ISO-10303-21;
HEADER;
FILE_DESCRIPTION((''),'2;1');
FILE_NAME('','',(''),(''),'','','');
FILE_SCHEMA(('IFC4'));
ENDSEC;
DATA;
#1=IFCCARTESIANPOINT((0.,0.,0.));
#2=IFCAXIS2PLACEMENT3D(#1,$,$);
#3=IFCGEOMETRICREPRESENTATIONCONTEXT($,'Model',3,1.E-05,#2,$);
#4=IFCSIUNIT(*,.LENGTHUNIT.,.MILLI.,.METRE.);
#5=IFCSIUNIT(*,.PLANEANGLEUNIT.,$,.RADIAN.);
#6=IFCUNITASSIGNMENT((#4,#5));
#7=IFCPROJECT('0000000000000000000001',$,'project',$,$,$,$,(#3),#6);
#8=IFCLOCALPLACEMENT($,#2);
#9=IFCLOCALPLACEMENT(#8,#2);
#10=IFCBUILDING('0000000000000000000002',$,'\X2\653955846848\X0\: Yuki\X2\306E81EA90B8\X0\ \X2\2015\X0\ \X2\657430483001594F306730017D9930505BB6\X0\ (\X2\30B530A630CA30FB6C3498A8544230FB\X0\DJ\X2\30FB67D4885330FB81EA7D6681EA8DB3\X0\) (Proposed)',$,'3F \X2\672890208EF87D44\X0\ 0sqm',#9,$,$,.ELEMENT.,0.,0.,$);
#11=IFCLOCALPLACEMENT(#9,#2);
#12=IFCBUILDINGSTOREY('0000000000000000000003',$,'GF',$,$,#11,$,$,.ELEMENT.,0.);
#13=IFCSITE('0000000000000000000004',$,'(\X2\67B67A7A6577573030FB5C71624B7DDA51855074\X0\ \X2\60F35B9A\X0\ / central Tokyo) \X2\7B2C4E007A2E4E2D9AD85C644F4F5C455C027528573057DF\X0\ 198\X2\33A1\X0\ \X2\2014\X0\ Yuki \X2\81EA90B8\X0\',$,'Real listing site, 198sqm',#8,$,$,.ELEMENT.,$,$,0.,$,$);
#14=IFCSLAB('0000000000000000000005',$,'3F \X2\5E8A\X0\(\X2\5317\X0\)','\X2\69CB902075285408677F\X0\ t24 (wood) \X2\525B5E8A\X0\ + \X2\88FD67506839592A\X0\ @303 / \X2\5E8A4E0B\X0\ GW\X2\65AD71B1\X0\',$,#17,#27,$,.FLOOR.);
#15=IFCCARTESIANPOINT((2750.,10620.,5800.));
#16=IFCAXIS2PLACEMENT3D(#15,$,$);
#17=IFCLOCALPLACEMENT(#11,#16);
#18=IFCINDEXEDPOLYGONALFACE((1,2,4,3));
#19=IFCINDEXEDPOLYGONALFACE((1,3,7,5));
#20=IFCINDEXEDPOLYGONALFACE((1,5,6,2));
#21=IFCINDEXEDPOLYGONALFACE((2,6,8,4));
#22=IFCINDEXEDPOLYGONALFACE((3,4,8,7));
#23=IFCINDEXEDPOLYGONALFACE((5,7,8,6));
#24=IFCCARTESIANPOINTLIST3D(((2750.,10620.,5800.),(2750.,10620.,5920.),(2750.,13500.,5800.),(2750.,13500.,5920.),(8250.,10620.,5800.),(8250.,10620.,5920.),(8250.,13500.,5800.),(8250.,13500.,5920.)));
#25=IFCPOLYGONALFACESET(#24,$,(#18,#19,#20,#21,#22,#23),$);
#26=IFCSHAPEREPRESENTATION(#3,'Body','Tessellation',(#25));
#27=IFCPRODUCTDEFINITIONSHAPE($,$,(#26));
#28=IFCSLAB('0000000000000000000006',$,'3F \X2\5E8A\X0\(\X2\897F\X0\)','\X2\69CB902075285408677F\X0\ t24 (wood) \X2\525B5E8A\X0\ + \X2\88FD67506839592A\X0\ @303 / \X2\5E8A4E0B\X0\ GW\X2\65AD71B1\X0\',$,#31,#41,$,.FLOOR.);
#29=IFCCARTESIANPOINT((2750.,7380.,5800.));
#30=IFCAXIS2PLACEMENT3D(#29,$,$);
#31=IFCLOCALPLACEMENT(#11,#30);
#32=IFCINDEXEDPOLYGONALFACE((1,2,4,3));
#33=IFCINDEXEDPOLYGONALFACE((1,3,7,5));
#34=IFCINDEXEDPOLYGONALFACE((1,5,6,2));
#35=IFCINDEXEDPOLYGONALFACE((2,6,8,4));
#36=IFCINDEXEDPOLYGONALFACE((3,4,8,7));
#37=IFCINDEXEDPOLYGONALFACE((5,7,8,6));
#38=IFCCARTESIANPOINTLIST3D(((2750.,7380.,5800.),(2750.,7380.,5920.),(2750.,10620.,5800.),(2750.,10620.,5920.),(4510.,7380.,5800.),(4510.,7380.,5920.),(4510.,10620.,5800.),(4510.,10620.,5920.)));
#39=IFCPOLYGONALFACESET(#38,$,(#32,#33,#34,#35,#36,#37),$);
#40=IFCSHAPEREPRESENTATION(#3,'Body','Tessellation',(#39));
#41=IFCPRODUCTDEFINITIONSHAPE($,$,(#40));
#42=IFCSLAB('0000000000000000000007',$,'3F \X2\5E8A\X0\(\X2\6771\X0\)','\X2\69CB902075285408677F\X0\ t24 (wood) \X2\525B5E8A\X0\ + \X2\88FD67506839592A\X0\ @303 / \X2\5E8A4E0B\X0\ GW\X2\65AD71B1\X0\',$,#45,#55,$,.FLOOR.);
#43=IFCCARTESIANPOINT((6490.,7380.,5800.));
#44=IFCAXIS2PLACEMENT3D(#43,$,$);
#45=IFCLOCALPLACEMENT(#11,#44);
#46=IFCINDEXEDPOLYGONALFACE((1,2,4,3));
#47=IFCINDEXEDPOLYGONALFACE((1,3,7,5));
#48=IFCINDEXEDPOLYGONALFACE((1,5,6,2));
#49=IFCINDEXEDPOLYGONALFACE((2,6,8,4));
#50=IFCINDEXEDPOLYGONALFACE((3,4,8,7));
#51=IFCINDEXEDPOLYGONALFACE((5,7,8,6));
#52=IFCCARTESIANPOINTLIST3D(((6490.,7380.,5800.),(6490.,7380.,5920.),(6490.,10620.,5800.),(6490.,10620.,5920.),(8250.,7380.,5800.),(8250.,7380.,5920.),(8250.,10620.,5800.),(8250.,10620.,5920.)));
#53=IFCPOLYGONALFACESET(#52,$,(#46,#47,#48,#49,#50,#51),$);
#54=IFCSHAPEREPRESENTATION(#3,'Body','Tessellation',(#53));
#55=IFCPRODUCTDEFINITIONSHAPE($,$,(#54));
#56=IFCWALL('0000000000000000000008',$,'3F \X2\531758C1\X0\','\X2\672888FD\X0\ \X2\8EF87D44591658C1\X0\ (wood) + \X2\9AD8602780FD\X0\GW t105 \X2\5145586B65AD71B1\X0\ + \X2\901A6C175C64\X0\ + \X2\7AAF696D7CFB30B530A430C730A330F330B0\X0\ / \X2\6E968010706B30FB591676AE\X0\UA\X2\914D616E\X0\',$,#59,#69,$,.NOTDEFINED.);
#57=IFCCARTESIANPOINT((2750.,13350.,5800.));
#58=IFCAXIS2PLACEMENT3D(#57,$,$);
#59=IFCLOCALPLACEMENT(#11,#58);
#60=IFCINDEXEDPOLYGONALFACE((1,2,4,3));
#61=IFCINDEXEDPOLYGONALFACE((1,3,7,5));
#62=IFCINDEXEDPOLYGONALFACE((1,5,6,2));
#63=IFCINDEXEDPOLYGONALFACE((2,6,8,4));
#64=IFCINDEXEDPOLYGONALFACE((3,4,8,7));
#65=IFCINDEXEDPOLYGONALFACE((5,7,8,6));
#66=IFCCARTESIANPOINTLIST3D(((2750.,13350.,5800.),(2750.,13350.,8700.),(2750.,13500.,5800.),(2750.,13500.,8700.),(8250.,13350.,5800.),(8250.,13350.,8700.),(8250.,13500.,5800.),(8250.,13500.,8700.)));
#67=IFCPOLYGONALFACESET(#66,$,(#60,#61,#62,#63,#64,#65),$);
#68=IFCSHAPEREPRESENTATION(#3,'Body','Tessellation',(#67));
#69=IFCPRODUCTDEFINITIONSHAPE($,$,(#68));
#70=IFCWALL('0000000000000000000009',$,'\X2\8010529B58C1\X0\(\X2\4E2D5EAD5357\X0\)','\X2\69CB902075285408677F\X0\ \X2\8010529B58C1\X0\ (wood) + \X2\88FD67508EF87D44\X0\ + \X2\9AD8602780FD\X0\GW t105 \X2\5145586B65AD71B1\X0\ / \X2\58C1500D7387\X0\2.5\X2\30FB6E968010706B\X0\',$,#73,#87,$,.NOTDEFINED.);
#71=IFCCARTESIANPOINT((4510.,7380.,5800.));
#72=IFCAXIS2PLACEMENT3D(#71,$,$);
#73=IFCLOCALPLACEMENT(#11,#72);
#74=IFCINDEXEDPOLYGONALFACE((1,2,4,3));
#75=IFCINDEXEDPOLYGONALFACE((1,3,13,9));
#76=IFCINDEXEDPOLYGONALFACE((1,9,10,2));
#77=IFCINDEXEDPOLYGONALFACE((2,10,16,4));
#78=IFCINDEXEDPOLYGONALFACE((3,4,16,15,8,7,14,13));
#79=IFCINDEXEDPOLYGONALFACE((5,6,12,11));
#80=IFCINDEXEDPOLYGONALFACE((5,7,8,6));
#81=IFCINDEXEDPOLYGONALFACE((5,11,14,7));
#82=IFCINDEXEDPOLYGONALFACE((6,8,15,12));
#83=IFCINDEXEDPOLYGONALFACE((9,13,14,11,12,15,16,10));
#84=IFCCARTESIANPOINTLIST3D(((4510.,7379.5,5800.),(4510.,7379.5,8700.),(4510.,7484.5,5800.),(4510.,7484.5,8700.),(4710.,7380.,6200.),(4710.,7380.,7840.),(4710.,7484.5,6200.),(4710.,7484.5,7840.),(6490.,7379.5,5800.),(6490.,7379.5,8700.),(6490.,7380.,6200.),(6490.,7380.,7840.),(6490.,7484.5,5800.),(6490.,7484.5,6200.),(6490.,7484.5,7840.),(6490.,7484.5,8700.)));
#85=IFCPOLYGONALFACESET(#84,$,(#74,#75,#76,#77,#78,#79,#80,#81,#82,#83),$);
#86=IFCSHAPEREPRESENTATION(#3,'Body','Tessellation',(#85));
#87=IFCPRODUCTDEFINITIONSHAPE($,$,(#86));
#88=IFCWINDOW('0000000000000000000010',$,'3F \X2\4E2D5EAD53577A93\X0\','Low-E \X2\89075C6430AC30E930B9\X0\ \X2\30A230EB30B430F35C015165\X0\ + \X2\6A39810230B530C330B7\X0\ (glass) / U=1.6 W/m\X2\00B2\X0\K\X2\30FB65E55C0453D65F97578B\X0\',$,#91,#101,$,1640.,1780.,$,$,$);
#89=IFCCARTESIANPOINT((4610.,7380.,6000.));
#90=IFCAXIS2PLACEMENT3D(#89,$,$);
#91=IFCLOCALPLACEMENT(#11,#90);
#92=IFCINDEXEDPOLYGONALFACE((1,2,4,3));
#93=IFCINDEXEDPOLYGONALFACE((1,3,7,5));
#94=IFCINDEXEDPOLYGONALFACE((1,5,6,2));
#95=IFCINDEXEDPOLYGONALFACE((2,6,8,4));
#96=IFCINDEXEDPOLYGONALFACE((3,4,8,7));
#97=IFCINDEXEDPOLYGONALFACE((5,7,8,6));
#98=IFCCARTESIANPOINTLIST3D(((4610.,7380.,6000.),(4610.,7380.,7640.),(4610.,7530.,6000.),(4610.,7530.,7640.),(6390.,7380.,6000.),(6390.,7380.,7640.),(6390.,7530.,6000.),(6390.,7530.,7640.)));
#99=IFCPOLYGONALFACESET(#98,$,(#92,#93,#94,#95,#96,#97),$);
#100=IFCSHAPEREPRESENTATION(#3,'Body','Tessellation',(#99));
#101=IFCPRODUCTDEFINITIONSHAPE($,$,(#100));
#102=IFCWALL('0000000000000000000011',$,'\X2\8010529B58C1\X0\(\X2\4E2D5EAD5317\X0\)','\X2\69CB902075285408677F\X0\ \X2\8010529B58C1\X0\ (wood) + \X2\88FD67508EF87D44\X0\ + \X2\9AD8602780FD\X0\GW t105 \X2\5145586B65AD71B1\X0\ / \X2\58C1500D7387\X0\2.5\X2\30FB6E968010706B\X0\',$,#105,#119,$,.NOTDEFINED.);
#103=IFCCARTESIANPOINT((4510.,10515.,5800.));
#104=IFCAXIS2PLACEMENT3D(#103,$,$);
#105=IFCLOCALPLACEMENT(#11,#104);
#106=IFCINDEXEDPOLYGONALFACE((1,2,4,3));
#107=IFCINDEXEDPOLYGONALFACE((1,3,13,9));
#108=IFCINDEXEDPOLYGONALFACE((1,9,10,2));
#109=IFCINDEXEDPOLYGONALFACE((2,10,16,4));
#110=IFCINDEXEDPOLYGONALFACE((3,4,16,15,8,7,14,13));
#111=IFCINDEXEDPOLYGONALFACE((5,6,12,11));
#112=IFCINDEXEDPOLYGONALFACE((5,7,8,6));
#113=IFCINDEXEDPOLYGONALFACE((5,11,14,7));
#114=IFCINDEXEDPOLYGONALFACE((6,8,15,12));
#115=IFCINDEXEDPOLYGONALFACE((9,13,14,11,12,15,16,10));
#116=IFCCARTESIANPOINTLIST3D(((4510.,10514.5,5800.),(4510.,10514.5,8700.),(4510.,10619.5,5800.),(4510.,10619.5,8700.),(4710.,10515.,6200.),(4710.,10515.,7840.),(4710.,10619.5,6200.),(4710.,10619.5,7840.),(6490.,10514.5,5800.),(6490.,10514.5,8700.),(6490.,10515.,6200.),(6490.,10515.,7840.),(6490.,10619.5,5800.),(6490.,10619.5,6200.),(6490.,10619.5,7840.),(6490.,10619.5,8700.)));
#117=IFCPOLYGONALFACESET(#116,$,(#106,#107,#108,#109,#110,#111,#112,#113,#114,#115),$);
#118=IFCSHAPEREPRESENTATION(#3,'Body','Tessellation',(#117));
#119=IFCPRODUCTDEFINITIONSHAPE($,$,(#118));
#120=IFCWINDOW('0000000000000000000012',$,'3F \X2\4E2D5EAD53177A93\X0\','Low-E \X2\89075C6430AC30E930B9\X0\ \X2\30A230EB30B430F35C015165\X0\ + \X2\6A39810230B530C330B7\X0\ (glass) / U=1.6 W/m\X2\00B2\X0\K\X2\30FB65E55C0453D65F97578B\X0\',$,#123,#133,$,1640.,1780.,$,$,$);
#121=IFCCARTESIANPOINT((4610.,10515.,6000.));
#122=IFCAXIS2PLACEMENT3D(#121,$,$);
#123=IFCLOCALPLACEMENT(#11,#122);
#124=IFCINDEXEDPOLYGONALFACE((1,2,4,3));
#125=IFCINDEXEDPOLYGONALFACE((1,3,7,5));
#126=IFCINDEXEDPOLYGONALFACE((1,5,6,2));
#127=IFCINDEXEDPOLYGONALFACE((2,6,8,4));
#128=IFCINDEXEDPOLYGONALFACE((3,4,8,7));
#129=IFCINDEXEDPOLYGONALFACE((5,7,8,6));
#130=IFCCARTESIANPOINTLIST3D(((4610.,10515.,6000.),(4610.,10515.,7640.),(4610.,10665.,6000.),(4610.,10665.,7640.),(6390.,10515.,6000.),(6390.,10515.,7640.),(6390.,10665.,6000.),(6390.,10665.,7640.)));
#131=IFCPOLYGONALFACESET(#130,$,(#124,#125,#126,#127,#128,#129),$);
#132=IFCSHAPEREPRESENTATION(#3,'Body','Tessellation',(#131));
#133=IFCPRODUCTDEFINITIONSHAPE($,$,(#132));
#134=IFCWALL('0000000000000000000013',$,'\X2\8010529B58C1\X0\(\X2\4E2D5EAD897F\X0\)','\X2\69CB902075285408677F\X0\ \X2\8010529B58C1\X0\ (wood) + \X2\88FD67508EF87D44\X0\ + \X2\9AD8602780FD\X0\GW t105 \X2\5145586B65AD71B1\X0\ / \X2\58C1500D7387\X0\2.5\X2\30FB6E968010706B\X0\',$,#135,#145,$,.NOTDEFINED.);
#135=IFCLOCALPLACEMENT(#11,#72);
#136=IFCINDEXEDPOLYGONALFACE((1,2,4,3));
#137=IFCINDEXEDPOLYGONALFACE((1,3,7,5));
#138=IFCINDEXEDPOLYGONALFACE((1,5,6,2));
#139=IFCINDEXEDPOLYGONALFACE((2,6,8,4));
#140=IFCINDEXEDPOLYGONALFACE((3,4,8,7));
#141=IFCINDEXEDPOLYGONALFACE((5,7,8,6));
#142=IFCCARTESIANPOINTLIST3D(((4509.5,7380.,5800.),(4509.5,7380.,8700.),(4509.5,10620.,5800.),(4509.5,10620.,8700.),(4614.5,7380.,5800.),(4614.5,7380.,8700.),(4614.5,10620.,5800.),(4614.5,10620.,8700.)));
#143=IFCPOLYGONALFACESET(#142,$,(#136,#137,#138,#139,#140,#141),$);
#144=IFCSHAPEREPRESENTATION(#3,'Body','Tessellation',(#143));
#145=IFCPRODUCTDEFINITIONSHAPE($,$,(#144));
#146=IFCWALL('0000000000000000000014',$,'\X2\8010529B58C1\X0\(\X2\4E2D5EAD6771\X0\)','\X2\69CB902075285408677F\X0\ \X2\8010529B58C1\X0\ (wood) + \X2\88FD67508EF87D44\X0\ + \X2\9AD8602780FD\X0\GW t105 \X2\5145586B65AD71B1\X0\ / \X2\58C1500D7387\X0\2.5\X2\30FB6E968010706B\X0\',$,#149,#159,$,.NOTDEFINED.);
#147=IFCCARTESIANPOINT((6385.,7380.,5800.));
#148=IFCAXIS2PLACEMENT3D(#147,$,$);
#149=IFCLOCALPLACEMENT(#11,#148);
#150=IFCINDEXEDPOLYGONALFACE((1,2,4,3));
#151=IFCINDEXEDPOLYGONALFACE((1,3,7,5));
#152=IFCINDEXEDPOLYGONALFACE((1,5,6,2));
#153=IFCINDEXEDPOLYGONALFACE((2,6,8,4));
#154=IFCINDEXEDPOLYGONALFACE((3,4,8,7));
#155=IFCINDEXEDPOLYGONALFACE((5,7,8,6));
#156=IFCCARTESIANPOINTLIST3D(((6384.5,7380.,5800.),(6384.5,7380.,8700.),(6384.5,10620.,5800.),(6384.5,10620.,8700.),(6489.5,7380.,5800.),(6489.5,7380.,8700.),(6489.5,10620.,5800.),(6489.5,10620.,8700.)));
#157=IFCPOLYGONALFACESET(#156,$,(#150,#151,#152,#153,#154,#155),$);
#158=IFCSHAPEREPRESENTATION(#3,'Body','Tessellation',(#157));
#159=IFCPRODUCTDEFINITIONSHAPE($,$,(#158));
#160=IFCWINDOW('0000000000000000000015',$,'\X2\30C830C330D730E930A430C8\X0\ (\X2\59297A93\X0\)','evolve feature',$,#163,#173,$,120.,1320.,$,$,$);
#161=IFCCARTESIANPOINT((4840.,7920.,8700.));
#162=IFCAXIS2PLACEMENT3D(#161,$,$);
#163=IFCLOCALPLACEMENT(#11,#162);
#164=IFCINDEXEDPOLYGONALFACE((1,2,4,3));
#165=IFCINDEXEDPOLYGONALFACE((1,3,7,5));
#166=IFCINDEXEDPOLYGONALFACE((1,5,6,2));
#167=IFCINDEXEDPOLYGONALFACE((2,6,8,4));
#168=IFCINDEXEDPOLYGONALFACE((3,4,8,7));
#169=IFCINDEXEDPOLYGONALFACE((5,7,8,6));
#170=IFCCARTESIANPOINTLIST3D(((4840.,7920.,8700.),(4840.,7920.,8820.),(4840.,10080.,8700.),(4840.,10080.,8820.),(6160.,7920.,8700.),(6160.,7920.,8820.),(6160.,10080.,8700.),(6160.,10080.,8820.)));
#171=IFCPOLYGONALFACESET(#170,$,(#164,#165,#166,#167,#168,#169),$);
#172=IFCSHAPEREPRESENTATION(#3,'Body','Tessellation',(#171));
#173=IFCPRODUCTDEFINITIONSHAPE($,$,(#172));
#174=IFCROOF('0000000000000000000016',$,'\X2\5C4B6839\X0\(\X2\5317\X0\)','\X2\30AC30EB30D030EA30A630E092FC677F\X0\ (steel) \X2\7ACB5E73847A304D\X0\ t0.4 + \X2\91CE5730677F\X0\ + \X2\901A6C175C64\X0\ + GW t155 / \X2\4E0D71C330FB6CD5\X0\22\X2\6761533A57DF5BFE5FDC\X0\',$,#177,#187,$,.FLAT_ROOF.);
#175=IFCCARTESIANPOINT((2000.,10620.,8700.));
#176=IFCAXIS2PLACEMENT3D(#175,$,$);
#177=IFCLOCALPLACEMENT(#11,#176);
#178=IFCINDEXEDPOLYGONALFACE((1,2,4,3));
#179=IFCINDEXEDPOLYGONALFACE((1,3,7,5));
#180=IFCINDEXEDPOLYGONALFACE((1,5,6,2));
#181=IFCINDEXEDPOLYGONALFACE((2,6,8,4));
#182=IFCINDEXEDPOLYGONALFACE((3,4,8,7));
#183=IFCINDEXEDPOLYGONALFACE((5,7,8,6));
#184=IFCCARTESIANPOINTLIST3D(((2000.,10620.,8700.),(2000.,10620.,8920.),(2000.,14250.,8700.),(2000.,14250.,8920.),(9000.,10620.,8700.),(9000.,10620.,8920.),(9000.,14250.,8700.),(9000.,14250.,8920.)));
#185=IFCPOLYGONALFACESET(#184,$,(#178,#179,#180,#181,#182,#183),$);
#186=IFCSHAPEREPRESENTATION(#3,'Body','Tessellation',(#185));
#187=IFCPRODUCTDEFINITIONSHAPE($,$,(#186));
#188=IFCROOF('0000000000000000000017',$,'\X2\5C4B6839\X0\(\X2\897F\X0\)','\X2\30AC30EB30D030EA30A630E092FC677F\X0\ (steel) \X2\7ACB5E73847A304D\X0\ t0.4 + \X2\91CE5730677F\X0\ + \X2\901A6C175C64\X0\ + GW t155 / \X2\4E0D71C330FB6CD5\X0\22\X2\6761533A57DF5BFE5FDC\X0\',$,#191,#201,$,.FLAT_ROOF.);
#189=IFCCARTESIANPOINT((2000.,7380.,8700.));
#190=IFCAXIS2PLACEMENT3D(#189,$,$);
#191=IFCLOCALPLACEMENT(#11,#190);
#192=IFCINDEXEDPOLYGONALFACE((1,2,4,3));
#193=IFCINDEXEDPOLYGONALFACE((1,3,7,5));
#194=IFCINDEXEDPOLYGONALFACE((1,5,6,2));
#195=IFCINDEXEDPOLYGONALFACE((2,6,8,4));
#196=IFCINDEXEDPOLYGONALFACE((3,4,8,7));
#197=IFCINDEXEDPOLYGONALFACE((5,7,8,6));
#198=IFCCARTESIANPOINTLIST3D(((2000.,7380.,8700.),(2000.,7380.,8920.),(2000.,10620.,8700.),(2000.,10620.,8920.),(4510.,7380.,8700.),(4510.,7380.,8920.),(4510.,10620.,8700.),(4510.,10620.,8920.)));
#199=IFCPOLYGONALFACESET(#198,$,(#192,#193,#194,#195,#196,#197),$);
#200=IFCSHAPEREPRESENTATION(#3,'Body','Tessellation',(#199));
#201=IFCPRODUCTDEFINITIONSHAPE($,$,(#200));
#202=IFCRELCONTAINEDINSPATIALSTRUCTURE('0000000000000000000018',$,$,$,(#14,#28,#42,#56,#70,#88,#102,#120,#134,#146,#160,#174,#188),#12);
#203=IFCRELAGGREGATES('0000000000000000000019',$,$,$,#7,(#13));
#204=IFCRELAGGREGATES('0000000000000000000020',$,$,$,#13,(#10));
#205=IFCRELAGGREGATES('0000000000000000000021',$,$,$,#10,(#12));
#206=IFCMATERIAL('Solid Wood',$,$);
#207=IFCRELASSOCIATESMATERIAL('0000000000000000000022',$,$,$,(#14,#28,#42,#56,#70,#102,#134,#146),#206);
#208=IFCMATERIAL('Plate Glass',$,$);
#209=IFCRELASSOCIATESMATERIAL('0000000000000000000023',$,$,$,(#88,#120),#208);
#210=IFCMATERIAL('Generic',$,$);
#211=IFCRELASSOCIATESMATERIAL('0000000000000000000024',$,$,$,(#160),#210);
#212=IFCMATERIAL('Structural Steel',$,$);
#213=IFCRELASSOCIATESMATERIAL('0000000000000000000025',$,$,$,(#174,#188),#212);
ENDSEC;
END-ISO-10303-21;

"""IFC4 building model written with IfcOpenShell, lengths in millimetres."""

from ifc_helpers import new_model, si_unit, frame, frame_2d, origin, place, context, project, spatial, rectangle, extrude, material, element, fill, save


model = new_model("IFC4")

# Units and contexts
model_context = context("Model", 3, precision=1e-05, world=origin())
ifc_project = project(units=[si_unit("LENGTHUNIT", "METRE", prefix="MILLI"), si_unit("PLANEANGLEUNIT", "RADIAN")], contexts=[model_context])

# Site, building, storey
site_placement = place(None, origin())
site = spatial("IfcSite", under=ifc_project, at=site_placement, Name="(架空敷地・山手線内側 想定 / central Tokyo) 第一種中高層住居専用地域 198㎡ — Yuki 自邸", ObjectType="Real listing site, 198sqm", CompositionType="ELEMENT", RefElevation=0.0)
building_placement = place(site_placement, origin())
building = spatial("IfcBuilding", under=site, at=building_placement, Name="改善案: Yukiの自邸 ― 整え、奏で、継ぐ家 (サウナ・水風呂・DJ・柔術・自給自足) (Proposed)", ObjectType="3F 木造軸組 0sqm", CompositionType="ELEMENT", ElevationOfRefHeight=0.0, ElevationOfTerrain=0.0)
storey_placement = place(building_placement, origin())
storey = spatial("IfcBuildingStorey", under=building, at=storey_placement, Name="GF", CompositionType="ELEMENT", Elevation=0.0)

# Slabs
ifc_material_1 = material(Name="Solid Wood")
slab_1_placement = place(storey_placement, frame((2750.0, 10620.0, 5800.0)))
element("IfcSlab", 1, at=slab_1_placement, inside=storey, material=ifc_material_1, Name="3F 床(北)", Description="構造用合板 t24 (wood) 剛床 + 製材根太 @303 / 床下 GW断熱", PredefinedType="FLOOR", context=model_context, shape_type="SweptSolid", body=[
    extrude(rectangle(XDim=5500.0, YDim=2880.0, at=frame_2d((2750.0, 1440.0))), frame((2750.0, 10620.0, 5800.0)), (0.0, 0.0, 1.0), 120.0),
])
slab_2_placement = place(storey_placement, frame((2750.0, 7380.0, 5800.0)))
element("IfcSlab", 2, at=slab_2_placement, inside=storey, material=ifc_material_1, Name="3F 床(西)", Description="構造用合板 t24 (wood) 剛床 + 製材根太 @303 / 床下 GW断熱", PredefinedType="FLOOR", context=model_context, shape_type="SweptSolid", body=[
    extrude(rectangle(XDim=1760.0, YDim=3240.0, at=frame_2d((880.0, 1620.0))), frame((2750.0, 7380.0, 5800.0)), (0.0, 0.0, 1.0), 120.0),
])
slab_3_placement = place(storey_placement, frame((6490.0, 7380.0, 5800.0)))
element("IfcSlab", 3, at=slab_3_placement, inside=storey, material=ifc_material_1, Name="3F 床(東)", Description="構造用合板 t24 (wood) 剛床 + 製材根太 @303 / 床下 GW断熱", PredefinedType="FLOOR", context=model_context, shape_type="SweptSolid", body=[
    extrude(rectangle(XDim=1760.0, YDim=3240.0, at=frame_2d((880.0, 1620.0))), frame((6490.0, 7380.0, 5800.0)), (0.0, 0.0, 1.0), 120.0),
])

# Wall
wall_1_placement = place(storey_placement, frame((2750.0, 13350.0, 5800.0)))
element("IfcWall", 4, at=wall_1_placement, inside=storey, material=ifc_material_1, Name="3F 北壁", Description="木製 軸組外壁 (wood) + 高性能GW t105 充填断熱 + 通気層 + 窯業系サイディング / 準耐火・外皮UA配慮", PredefinedType="NOTDEFINED", context=model_context, shape_type="SweptSolid", body=[
    extrude(rectangle(XDim=5500.0, YDim=150.0, at=frame_2d((2750.0, 75.0))), frame((2750.0, 13350.0, 5800.0)), (0.0, 0.0, 1.0), 2900.0),
])

# Walls, openings, windows
wall_2_placement = place(storey_placement, frame((4510.0, 7380.0, 5800.0)))
wall_2 = element("IfcWall", 5, at=wall_2_placement, inside=storey, material=ifc_material_1, Name="耐力壁(中庭南)", Description="構造用合板 耐力壁 (wood) + 製材軸組 + 高性能GW t105 充填断熱 / 壁倍率2.5・準耐火", PredefinedType="NOTDEFINED", context=model_context, shape_type="SweptSolid", body=[
    extrude(rectangle(XDim=1980.0, YDim=105.0, at=frame_2d((990.0, 52.0))), frame((4510.0, 7380.0, 5800.0)), (0.0, 0.0, 1.0), 2900.0),
])
opening_1_placement = place(storey_placement, frame((4610.0, 7380.0, 6000.0)))
opening_1 = element("IfcOpeningElement", 6, at=opening_1_placement, cuts=wall_2, PredefinedType="NOTDEFINED", context=model_context, shape_type="SweptSolid", body=[
    extrude(rectangle(XDim=1780.0, YDim=150.0, at=frame_2d((890.0, 75.0))), frame((4610.0, 7380.0, 6000.0)), (0.0, 0.0, 1.0), 1640.0),
])
ifc_material_2 = material(Name="Plate Glass")
window_1_placement = place(storey_placement, frame((4610.0, 7380.0, 6000.0)))
window_1 = element("IfcWindow", 7, at=window_1_placement, inside=storey, material=ifc_material_2, Name="3F 中庭南窓", Description="Low-E 複層ガラス アルゴン封入 + 樹脂サッシ (glass) / U=1.6 W/m²K・日射取得型", OverallHeight=1640.0, OverallWidth=1780.0, context=model_context, shape_type="SweptSolid", body=[
    extrude(rectangle(XDim=1780.0, YDim=150.0, at=frame_2d((890.0, 75.0))), frame((4610.0, 7380.0, 6000.0)), (0.0, 0.0, 1.0), 1640.0),
])
fill(opening_1, window_1)
wall_3_placement = place(storey_placement, frame((4510.0, 10515.0, 5800.0)))
wall_3 = element("IfcWall", 8, at=wall_3_placement, inside=storey, material=ifc_material_1, Name="耐力壁(中庭北)", Description="構造用合板 耐力壁 (wood) + 製材軸組 + 高性能GW t105 充填断熱 / 壁倍率2.5・準耐火", PredefinedType="NOTDEFINED", context=model_context, shape_type="SweptSolid", body=[
    extrude(rectangle(XDim=1980.0, YDim=105.0, at=frame_2d((990.0, 52.0))), frame((4510.0, 10515.0, 5800.0)), (0.0, 0.0, 1.0), 2900.0),
])
opening_2_placement = place(storey_placement, frame((4610.0, 10515.0, 6000.0)))
opening_2 = element("IfcOpeningElement", 9, at=opening_2_placement, cuts=wall_3, PredefinedType="NOTDEFINED", context=model_context, shape_type="SweptSolid", body=[
    extrude(rectangle(XDim=1780.0, YDim=150.0, at=frame_2d((890.0, 75.0))), frame((4610.0, 10515.0, 6000.0)), (0.0, 0.0, 1.0), 1640.0),
])
window_2_placement = place(storey_placement, frame((4610.0, 10515.0, 6000.0)))
window_2 = element("IfcWindow", 10, at=window_2_placement, inside=storey, material=ifc_material_2, Name="3F 中庭北窓", Description="Low-E 複層ガラス アルゴン封入 + 樹脂サッシ (glass) / U=1.6 W/m²K・日射取得型", OverallHeight=1640.0, OverallWidth=1780.0, context=model_context, shape_type="SweptSolid", body=[
    extrude(rectangle(XDim=1780.0, YDim=150.0, at=frame_2d((890.0, 75.0))), frame((4610.0, 10515.0, 6000.0)), (0.0, 0.0, 1.0), 1640.0),
])
fill(opening_2, window_2)

# Walls
wall_4_placement = place(storey_placement, frame((4510.0, 7380.0, 5800.0)))
element("IfcWall", 11, at=wall_4_placement, inside=storey, material=ifc_material_1, Name="耐力壁(中庭西)", Description="構造用合板 耐力壁 (wood) + 製材軸組 + 高性能GW t105 充填断熱 / 壁倍率2.5・準耐火", PredefinedType="NOTDEFINED", context=model_context, shape_type="SweptSolid", body=[
    extrude(rectangle(XDim=105.0, YDim=3240.0, at=frame_2d((52.0, 1620.0))), frame((4510.0, 7380.0, 5800.0)), (0.0, 0.0, 1.0), 2900.0),
])
wall_5_placement = place(storey_placement, frame((6385.0, 7380.0, 5800.0)))
element("IfcWall", 12, at=wall_5_placement, inside=storey, material=ifc_material_1, Name="耐力壁(中庭東)", Description="構造用合板 耐力壁 (wood) + 製材軸組 + 高性能GW t105 充填断熱 / 壁倍率2.5・準耐火", PredefinedType="NOTDEFINED", context=model_context, shape_type="SweptSolid", body=[
    extrude(rectangle(XDim=105.0, YDim=3240.0, at=frame_2d((52.0, 1620.0))), frame((6385.0, 7380.0, 5800.0)), (0.0, 0.0, 1.0), 2900.0),
])

# Window
ifc_material_3 = material(Name="Generic")
window_3_placement = place(storey_placement, frame((4840.0, 7920.0, 8700.0)))
element("IfcWindow", 13, at=window_3_placement, inside=storey, material=ifc_material_3, Name="トップライト (天窓)", Description="evolve feature", OverallHeight=120.0, OverallWidth=1320.0, context=model_context, shape_type="SweptSolid", body=[
    extrude(rectangle(XDim=1320.0, YDim=2160.0, at=frame_2d((660.0, 1080.0))), frame((4840.0, 7920.0, 8700.0)), (0.0, 0.0, 1.0), 120.0),
])

# Roofs
ifc_material_4 = material(Name="Structural Steel")
for number, where, name in (
    (14, (2000.0, 10620.0, 8700.0), "屋根(北)"),
):
    element("IfcRoof", number, at=place(storey_placement, frame(where)), inside=storey, material=ifc_material_4, Name=name, Description="ガルバリウム鋼板 (steel) 立平葺き t0.4 + 野地板 + 通気層 + GW t155 / 不燃・法22条区域対応", PredefinedType="FLAT_ROOF", context=model_context, shape_type="SweptSolid", body=[
        extrude(rectangle(XDim=7000.0, YDim=3630.0, at=frame_2d((3500.0, 1815.0))), frame((2000.0, 10620.0, 8700.0)), (0.0, 0.0, 1.0), 220.0),
    ])
roof_1_placement = place(storey_placement, frame((2000.0, 7380.0, 8700.0)))
element("IfcRoof", 15, at=roof_1_placement, inside=storey, material=ifc_material_4, Name="屋根(西)", Description="ガルバリウム鋼板 (steel) 立平葺き t0.4 + 野地板 + 通気層 + GW t155 / 不燃・法22条区域対応", PredefinedType="FLAT_ROOF", context=model_context, shape_type="SweptSolid", body=[
    extrude(rectangle(XDim=2510.0, YDim=3240.0, at=frame_2d((1255.0, 1620.0))), frame((2000.0, 7380.0, 8700.0)), (0.0, 0.0, 1.0), 220.0),
])

save(model, "model.ifc")
